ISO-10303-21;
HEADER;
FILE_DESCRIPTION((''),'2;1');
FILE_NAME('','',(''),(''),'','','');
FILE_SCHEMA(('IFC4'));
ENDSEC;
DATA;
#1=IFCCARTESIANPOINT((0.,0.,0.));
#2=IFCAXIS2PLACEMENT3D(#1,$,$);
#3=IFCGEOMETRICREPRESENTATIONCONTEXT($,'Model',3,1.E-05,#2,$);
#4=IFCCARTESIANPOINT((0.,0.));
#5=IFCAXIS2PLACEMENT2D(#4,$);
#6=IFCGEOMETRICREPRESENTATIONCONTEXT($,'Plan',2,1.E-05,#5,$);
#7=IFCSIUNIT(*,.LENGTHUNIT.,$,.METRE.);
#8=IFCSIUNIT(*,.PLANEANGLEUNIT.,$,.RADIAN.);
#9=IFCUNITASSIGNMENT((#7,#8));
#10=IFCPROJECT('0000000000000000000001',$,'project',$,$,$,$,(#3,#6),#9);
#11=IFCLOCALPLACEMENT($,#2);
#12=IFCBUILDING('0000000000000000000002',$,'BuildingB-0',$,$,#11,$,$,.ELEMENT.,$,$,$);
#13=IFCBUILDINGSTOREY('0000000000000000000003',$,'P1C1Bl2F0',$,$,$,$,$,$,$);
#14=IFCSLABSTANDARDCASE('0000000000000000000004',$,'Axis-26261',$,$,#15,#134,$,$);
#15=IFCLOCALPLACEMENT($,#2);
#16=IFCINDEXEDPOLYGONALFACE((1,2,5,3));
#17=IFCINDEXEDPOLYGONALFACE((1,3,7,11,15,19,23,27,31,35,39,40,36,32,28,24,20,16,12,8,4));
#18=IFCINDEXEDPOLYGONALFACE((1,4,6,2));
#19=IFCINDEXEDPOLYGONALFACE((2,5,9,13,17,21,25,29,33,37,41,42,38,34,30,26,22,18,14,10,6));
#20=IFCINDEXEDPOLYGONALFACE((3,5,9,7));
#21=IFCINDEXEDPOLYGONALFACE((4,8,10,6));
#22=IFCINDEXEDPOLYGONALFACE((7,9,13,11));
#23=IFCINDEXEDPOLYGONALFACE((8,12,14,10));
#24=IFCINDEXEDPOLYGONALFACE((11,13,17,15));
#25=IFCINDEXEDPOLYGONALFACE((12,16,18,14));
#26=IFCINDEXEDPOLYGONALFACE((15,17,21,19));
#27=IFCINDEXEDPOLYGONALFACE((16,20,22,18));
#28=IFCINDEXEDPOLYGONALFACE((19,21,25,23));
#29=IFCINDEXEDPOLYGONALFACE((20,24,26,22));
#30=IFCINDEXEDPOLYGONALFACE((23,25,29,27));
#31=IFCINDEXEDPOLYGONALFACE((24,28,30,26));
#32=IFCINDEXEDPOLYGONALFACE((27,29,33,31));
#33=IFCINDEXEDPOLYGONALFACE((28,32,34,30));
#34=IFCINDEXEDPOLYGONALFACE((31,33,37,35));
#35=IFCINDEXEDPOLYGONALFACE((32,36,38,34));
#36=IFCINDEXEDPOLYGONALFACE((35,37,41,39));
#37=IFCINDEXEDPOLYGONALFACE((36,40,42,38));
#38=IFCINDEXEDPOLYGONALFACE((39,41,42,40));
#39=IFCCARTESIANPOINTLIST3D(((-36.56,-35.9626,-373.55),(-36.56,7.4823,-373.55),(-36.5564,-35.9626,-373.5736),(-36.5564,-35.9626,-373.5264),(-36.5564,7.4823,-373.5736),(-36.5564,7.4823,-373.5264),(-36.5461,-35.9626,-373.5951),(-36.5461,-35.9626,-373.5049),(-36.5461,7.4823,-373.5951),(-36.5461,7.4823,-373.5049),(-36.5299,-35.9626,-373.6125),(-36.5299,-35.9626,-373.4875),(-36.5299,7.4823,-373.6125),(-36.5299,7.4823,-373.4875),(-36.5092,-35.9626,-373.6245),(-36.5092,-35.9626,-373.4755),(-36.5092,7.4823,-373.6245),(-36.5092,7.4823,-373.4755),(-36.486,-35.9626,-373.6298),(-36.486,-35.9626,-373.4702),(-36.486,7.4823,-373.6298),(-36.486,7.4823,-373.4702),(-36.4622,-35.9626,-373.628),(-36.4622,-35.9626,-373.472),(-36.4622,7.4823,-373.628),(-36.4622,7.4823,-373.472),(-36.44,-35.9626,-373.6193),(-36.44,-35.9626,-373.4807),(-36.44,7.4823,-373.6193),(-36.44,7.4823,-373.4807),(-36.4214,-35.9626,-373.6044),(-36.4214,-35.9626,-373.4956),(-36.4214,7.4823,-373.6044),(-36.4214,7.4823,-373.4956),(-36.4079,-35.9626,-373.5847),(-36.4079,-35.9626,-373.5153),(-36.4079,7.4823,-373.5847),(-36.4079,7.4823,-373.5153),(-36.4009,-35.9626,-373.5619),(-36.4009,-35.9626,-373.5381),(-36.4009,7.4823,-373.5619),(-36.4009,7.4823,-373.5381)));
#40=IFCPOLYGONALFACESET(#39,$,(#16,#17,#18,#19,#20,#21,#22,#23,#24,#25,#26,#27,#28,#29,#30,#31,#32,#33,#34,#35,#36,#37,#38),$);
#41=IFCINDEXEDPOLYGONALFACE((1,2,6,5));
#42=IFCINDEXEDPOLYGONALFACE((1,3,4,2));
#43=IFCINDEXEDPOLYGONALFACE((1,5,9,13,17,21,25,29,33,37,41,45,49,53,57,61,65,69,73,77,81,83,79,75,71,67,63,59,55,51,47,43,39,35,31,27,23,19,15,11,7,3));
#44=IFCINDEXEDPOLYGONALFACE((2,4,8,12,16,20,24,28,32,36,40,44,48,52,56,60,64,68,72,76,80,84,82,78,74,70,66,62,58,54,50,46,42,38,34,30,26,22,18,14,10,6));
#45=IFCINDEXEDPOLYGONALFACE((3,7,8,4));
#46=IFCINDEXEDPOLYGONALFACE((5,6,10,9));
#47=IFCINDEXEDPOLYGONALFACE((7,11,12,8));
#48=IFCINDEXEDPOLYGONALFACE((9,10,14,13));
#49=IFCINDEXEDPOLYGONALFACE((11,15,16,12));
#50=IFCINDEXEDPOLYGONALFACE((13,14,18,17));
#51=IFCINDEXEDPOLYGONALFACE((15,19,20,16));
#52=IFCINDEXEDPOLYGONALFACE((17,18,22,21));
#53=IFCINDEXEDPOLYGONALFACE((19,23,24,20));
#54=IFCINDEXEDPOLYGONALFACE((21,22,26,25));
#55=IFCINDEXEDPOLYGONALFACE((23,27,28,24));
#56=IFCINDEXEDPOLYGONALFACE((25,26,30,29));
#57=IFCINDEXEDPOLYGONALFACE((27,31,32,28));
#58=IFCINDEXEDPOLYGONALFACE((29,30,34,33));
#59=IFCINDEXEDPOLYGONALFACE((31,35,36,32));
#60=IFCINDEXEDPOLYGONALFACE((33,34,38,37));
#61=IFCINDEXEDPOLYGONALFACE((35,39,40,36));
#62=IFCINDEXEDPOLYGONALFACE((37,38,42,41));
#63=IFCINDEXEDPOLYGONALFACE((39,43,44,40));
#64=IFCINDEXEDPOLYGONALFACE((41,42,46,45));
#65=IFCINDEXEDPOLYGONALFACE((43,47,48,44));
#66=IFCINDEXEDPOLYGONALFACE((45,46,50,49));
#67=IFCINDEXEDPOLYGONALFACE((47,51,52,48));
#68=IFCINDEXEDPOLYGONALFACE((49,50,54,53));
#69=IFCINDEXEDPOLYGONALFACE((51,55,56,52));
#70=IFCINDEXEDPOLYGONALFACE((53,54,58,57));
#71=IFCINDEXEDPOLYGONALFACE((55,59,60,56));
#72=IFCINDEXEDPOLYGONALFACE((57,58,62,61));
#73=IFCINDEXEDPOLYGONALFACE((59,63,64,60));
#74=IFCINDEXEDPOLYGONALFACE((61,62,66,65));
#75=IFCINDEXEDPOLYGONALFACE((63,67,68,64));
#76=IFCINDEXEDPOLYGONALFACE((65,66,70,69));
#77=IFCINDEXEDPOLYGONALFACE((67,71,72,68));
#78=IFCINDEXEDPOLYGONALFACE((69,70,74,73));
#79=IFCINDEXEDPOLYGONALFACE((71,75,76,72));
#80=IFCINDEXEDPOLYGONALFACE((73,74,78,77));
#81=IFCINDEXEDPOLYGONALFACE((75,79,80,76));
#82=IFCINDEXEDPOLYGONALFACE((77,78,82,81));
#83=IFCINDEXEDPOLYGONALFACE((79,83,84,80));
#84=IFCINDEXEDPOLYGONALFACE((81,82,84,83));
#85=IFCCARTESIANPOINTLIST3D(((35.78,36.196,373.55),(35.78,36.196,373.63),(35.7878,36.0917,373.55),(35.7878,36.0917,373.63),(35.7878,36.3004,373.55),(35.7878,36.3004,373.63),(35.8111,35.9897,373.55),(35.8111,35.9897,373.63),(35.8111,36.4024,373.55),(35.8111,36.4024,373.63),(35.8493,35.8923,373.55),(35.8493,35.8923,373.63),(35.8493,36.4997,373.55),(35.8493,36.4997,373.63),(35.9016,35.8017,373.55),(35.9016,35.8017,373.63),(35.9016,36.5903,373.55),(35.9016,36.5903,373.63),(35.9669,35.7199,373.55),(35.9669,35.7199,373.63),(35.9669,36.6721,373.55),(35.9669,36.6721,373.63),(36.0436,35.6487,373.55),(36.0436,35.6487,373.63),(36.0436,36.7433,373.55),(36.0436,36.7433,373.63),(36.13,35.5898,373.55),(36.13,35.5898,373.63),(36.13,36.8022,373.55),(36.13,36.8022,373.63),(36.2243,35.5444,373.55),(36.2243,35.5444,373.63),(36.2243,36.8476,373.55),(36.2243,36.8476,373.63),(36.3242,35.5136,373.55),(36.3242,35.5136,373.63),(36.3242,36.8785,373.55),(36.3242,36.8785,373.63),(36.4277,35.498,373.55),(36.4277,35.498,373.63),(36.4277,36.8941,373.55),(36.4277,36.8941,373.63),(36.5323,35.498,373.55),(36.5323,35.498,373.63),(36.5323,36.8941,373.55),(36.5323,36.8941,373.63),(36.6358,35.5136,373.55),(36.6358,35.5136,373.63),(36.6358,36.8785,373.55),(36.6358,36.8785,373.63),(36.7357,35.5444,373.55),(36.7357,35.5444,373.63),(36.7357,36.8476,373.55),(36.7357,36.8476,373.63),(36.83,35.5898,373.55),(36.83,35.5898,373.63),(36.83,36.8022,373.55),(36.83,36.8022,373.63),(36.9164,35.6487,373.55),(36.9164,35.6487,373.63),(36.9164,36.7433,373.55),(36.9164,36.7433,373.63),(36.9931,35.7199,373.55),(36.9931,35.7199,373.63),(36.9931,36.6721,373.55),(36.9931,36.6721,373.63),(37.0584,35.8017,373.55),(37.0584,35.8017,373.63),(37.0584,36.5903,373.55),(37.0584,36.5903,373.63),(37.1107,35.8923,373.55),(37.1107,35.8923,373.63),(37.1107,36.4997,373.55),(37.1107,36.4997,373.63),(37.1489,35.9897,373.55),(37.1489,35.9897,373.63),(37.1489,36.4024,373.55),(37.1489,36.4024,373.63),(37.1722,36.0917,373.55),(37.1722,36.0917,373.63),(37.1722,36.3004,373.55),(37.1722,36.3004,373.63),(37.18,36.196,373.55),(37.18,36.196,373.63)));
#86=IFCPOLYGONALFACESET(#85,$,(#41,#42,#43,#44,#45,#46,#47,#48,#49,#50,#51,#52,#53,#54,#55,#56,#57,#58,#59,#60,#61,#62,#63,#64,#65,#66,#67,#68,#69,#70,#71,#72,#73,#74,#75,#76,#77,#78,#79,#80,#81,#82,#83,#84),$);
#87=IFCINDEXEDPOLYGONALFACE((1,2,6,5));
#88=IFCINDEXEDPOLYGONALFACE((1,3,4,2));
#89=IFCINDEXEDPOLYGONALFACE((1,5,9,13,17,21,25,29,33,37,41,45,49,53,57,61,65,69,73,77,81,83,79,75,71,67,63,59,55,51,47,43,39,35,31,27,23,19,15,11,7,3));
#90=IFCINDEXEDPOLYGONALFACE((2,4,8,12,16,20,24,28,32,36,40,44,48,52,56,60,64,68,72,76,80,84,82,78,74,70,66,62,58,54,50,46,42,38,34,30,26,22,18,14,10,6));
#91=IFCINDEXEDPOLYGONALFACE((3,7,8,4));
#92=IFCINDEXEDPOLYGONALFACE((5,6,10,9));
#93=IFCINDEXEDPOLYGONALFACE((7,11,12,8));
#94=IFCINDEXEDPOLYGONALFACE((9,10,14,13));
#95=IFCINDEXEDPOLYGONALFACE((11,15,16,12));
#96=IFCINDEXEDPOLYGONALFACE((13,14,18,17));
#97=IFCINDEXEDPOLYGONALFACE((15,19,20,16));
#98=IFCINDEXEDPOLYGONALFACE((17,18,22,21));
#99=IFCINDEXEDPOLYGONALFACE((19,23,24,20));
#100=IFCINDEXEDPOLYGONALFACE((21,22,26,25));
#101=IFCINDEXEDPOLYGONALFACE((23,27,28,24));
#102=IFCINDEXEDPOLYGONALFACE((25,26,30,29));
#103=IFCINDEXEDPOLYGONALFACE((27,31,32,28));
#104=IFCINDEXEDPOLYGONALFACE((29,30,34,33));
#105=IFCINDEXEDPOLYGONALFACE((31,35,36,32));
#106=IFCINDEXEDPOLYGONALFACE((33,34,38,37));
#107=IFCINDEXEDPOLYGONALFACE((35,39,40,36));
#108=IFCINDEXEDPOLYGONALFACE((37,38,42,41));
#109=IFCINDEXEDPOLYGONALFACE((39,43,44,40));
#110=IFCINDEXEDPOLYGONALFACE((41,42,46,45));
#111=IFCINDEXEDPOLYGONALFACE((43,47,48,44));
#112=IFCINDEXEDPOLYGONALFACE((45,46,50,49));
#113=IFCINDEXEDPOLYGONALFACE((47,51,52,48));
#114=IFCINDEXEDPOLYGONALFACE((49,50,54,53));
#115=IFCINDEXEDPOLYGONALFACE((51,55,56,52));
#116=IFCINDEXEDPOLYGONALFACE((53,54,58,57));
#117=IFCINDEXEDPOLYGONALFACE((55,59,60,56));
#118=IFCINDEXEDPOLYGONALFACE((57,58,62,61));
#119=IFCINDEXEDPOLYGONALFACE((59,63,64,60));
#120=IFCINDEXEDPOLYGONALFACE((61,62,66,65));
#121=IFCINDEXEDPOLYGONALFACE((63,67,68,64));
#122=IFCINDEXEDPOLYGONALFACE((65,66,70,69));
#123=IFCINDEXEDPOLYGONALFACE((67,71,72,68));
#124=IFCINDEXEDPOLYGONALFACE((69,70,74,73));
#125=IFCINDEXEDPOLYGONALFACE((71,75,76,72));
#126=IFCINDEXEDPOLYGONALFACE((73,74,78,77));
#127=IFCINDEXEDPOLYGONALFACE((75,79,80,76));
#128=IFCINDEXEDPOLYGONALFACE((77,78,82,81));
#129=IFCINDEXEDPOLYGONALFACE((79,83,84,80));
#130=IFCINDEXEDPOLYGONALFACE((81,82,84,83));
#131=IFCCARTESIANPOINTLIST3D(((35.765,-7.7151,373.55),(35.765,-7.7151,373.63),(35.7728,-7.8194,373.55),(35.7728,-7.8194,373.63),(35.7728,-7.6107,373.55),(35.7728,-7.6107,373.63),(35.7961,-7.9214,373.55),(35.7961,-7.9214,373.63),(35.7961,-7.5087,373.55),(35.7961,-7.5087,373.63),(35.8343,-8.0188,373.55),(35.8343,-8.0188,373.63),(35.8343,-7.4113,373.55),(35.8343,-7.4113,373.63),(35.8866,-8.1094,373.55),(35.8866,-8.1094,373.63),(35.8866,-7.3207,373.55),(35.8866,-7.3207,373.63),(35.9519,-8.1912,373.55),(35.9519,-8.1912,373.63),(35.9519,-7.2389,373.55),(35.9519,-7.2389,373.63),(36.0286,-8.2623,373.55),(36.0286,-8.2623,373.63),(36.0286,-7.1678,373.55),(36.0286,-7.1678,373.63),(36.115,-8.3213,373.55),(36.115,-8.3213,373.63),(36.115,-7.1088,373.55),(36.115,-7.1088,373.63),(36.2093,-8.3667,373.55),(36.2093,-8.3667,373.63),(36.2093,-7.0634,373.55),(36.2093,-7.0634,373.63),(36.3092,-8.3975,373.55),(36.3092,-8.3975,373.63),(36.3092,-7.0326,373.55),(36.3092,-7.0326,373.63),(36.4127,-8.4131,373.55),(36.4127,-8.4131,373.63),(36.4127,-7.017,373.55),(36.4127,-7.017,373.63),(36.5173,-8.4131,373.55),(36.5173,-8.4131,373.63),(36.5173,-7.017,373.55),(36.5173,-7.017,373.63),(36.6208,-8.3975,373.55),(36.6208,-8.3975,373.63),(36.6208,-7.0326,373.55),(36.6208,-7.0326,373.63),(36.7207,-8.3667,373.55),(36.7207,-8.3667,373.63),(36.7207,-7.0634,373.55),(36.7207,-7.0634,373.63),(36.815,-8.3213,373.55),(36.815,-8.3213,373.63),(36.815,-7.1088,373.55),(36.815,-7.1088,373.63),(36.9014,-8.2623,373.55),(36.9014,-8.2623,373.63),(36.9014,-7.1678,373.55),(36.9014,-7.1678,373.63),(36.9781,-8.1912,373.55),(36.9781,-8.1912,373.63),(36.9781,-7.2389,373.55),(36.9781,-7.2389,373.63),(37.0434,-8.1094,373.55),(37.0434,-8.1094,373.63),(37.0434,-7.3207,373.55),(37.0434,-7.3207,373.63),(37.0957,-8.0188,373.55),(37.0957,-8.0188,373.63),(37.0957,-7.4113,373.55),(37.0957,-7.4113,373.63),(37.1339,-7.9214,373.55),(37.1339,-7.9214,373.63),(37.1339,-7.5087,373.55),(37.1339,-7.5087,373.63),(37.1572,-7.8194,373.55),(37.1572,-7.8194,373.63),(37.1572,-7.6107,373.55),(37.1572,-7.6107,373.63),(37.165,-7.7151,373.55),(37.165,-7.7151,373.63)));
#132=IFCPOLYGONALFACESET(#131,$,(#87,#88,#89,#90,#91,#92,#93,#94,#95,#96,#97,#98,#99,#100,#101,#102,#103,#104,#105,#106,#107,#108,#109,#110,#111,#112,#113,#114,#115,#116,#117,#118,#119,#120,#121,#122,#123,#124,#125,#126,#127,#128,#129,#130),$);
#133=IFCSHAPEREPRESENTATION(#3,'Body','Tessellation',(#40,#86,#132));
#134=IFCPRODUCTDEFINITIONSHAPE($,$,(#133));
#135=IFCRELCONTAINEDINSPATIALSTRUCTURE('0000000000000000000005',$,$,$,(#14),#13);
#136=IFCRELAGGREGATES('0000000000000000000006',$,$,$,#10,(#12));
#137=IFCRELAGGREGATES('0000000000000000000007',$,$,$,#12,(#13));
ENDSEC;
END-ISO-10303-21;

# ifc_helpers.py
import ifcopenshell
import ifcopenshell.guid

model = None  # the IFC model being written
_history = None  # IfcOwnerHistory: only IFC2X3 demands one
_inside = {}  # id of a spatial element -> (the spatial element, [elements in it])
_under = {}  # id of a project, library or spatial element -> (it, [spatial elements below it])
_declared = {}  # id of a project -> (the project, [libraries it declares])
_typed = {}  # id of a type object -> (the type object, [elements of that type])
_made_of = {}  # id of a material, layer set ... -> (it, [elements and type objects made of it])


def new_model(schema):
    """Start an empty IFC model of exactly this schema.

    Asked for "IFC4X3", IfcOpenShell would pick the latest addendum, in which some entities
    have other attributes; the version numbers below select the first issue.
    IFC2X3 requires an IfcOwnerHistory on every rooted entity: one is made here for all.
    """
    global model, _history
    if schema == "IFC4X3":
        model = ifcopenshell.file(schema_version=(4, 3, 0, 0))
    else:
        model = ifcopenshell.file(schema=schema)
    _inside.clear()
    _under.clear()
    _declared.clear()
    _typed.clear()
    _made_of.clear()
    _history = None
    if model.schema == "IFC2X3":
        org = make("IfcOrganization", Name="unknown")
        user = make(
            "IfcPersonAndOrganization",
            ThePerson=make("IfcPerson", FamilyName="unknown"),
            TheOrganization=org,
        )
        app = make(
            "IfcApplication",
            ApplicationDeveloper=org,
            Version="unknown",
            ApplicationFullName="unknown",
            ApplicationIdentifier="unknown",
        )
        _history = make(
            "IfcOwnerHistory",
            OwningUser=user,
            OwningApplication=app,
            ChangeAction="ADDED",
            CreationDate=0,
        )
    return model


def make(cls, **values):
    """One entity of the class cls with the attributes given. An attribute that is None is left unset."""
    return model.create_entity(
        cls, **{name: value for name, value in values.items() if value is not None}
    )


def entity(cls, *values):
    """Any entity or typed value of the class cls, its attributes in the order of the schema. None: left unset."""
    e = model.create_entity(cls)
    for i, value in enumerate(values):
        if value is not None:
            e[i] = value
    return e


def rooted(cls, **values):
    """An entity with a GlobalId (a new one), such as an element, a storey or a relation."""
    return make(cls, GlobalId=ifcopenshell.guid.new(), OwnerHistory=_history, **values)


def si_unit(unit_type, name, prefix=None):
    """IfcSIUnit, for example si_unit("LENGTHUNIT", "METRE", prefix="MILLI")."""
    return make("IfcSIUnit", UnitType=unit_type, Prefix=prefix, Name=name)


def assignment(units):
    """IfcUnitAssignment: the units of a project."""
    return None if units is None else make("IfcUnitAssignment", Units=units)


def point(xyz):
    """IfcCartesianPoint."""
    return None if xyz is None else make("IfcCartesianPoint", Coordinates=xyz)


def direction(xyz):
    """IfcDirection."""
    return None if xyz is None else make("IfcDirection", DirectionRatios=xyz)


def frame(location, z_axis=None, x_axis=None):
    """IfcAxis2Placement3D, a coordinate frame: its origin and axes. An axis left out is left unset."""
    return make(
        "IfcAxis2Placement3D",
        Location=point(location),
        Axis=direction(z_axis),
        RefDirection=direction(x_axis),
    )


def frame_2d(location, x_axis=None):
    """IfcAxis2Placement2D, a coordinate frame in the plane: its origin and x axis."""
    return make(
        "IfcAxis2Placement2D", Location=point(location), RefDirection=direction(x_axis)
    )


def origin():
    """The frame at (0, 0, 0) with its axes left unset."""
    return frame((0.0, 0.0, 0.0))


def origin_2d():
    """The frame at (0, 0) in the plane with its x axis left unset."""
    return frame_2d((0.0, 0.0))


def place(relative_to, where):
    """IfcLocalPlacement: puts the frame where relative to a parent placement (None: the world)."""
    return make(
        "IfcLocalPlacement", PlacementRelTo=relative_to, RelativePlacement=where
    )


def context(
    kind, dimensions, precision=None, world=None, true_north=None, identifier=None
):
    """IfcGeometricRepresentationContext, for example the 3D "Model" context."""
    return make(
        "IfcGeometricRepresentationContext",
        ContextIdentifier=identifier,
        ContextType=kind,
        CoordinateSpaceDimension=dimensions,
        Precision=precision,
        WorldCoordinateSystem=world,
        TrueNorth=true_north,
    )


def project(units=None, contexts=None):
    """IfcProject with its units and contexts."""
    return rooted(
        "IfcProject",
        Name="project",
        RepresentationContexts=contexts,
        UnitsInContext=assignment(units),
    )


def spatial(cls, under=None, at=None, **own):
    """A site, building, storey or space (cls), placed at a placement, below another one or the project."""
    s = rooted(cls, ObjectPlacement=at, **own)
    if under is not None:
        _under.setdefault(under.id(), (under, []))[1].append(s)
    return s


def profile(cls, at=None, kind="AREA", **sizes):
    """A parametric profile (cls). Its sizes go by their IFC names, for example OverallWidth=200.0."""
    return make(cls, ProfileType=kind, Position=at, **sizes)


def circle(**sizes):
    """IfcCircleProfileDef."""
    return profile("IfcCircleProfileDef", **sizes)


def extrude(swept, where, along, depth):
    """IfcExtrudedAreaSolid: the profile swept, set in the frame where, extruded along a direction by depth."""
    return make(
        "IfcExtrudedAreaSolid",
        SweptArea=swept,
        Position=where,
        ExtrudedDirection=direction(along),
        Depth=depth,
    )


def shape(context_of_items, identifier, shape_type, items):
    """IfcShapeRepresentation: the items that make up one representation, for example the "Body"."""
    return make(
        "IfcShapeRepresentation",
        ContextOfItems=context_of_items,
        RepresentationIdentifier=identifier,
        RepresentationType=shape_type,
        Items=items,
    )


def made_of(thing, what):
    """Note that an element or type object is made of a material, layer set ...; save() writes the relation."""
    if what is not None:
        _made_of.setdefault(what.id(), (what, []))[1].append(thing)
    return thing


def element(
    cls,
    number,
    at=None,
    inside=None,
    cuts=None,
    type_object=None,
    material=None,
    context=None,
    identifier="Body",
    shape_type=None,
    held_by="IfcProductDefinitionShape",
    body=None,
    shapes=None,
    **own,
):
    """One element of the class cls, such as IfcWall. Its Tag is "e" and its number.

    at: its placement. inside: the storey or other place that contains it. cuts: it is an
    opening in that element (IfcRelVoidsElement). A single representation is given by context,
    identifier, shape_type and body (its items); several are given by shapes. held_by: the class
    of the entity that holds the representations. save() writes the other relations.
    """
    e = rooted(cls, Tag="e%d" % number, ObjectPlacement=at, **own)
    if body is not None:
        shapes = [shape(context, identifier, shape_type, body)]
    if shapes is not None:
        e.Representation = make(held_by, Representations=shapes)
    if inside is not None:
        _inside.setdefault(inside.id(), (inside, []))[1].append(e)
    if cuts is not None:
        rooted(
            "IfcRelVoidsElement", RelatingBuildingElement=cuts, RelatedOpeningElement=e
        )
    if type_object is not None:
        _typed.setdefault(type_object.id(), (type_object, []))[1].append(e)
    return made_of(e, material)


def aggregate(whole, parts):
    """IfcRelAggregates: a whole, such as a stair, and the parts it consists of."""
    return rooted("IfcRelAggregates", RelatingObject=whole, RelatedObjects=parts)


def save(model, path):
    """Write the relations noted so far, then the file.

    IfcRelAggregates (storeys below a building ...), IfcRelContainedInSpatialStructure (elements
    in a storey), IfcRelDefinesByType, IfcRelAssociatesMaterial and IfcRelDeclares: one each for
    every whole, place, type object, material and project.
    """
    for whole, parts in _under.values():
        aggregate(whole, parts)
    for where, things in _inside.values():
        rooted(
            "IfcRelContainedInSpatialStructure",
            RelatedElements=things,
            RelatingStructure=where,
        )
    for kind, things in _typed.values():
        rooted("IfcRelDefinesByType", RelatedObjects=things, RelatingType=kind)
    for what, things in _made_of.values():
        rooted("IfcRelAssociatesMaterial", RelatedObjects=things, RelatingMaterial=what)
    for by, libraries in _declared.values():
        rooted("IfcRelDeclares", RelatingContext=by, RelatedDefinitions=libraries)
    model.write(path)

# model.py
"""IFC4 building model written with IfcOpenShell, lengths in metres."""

from ifc_helpers import new_model, entity, si_unit, frame, origin, origin_2d, place, context, project, spatial, circle, extrude, element, save


model = new_model("IFC4")

# Units and contexts
model_context = context("Model", 3, precision=1e-05, world=origin())
plan_context = context("Plan", 2, precision=1e-05, world=origin_2d())
ifc_project = project(units=[si_unit("LENGTHUNIT", "METRE"), si_unit("PLANEANGLEUNIT", "RADIAN")], contexts=[model_context, plan_context])

# Building, storey
building_placement = place(None, origin())
building = spatial("IfcBuilding", under=ifc_project, at=building_placement, Name="BuildingB-0", CompositionType="ELEMENT")
storey = spatial("IfcBuildingStorey", under=building, Name="P1C1Bl2F0")

# Slab
element("IfcSlabStandardCase", 1, inside=storey, Name="Axis-26261", context=model_context, shape_type="AdvancedSweptSolid", body=[
    entity("IfcSurfaceCurveSweptAreaSolid", entity("IfcCircleProfileDef", "AREA", None, None, 0.08), None, entity("IfcPolyline", [entity("IfcCartesianPoint", [36.48, 35.9626, 373.55]), entity("IfcCartesianPoint", [36.48, -7.4823, 373.55])]), None, None, entity("IfcPlane", entity("IfcAxis2Placement3D", entity("IfcCartesianPoint", [36.48, 35.9626, 373.55]), entity("IfcDirection", [0.0, 0.0, 1.0]), entity("IfcDirection", [1.0, 0.0, 0.0])))),
    extrude(circle(Radius=0.7), frame((36.48, 36.196, 373.55)), (0.0, 0.0, 1.0), 0.08),
    extrude(circle(Radius=0.7), frame((36.465, -7.7151, 373.55)), (0.0, 0.0, 1.0), 0.08),
])

save(model, "model.ifc")
